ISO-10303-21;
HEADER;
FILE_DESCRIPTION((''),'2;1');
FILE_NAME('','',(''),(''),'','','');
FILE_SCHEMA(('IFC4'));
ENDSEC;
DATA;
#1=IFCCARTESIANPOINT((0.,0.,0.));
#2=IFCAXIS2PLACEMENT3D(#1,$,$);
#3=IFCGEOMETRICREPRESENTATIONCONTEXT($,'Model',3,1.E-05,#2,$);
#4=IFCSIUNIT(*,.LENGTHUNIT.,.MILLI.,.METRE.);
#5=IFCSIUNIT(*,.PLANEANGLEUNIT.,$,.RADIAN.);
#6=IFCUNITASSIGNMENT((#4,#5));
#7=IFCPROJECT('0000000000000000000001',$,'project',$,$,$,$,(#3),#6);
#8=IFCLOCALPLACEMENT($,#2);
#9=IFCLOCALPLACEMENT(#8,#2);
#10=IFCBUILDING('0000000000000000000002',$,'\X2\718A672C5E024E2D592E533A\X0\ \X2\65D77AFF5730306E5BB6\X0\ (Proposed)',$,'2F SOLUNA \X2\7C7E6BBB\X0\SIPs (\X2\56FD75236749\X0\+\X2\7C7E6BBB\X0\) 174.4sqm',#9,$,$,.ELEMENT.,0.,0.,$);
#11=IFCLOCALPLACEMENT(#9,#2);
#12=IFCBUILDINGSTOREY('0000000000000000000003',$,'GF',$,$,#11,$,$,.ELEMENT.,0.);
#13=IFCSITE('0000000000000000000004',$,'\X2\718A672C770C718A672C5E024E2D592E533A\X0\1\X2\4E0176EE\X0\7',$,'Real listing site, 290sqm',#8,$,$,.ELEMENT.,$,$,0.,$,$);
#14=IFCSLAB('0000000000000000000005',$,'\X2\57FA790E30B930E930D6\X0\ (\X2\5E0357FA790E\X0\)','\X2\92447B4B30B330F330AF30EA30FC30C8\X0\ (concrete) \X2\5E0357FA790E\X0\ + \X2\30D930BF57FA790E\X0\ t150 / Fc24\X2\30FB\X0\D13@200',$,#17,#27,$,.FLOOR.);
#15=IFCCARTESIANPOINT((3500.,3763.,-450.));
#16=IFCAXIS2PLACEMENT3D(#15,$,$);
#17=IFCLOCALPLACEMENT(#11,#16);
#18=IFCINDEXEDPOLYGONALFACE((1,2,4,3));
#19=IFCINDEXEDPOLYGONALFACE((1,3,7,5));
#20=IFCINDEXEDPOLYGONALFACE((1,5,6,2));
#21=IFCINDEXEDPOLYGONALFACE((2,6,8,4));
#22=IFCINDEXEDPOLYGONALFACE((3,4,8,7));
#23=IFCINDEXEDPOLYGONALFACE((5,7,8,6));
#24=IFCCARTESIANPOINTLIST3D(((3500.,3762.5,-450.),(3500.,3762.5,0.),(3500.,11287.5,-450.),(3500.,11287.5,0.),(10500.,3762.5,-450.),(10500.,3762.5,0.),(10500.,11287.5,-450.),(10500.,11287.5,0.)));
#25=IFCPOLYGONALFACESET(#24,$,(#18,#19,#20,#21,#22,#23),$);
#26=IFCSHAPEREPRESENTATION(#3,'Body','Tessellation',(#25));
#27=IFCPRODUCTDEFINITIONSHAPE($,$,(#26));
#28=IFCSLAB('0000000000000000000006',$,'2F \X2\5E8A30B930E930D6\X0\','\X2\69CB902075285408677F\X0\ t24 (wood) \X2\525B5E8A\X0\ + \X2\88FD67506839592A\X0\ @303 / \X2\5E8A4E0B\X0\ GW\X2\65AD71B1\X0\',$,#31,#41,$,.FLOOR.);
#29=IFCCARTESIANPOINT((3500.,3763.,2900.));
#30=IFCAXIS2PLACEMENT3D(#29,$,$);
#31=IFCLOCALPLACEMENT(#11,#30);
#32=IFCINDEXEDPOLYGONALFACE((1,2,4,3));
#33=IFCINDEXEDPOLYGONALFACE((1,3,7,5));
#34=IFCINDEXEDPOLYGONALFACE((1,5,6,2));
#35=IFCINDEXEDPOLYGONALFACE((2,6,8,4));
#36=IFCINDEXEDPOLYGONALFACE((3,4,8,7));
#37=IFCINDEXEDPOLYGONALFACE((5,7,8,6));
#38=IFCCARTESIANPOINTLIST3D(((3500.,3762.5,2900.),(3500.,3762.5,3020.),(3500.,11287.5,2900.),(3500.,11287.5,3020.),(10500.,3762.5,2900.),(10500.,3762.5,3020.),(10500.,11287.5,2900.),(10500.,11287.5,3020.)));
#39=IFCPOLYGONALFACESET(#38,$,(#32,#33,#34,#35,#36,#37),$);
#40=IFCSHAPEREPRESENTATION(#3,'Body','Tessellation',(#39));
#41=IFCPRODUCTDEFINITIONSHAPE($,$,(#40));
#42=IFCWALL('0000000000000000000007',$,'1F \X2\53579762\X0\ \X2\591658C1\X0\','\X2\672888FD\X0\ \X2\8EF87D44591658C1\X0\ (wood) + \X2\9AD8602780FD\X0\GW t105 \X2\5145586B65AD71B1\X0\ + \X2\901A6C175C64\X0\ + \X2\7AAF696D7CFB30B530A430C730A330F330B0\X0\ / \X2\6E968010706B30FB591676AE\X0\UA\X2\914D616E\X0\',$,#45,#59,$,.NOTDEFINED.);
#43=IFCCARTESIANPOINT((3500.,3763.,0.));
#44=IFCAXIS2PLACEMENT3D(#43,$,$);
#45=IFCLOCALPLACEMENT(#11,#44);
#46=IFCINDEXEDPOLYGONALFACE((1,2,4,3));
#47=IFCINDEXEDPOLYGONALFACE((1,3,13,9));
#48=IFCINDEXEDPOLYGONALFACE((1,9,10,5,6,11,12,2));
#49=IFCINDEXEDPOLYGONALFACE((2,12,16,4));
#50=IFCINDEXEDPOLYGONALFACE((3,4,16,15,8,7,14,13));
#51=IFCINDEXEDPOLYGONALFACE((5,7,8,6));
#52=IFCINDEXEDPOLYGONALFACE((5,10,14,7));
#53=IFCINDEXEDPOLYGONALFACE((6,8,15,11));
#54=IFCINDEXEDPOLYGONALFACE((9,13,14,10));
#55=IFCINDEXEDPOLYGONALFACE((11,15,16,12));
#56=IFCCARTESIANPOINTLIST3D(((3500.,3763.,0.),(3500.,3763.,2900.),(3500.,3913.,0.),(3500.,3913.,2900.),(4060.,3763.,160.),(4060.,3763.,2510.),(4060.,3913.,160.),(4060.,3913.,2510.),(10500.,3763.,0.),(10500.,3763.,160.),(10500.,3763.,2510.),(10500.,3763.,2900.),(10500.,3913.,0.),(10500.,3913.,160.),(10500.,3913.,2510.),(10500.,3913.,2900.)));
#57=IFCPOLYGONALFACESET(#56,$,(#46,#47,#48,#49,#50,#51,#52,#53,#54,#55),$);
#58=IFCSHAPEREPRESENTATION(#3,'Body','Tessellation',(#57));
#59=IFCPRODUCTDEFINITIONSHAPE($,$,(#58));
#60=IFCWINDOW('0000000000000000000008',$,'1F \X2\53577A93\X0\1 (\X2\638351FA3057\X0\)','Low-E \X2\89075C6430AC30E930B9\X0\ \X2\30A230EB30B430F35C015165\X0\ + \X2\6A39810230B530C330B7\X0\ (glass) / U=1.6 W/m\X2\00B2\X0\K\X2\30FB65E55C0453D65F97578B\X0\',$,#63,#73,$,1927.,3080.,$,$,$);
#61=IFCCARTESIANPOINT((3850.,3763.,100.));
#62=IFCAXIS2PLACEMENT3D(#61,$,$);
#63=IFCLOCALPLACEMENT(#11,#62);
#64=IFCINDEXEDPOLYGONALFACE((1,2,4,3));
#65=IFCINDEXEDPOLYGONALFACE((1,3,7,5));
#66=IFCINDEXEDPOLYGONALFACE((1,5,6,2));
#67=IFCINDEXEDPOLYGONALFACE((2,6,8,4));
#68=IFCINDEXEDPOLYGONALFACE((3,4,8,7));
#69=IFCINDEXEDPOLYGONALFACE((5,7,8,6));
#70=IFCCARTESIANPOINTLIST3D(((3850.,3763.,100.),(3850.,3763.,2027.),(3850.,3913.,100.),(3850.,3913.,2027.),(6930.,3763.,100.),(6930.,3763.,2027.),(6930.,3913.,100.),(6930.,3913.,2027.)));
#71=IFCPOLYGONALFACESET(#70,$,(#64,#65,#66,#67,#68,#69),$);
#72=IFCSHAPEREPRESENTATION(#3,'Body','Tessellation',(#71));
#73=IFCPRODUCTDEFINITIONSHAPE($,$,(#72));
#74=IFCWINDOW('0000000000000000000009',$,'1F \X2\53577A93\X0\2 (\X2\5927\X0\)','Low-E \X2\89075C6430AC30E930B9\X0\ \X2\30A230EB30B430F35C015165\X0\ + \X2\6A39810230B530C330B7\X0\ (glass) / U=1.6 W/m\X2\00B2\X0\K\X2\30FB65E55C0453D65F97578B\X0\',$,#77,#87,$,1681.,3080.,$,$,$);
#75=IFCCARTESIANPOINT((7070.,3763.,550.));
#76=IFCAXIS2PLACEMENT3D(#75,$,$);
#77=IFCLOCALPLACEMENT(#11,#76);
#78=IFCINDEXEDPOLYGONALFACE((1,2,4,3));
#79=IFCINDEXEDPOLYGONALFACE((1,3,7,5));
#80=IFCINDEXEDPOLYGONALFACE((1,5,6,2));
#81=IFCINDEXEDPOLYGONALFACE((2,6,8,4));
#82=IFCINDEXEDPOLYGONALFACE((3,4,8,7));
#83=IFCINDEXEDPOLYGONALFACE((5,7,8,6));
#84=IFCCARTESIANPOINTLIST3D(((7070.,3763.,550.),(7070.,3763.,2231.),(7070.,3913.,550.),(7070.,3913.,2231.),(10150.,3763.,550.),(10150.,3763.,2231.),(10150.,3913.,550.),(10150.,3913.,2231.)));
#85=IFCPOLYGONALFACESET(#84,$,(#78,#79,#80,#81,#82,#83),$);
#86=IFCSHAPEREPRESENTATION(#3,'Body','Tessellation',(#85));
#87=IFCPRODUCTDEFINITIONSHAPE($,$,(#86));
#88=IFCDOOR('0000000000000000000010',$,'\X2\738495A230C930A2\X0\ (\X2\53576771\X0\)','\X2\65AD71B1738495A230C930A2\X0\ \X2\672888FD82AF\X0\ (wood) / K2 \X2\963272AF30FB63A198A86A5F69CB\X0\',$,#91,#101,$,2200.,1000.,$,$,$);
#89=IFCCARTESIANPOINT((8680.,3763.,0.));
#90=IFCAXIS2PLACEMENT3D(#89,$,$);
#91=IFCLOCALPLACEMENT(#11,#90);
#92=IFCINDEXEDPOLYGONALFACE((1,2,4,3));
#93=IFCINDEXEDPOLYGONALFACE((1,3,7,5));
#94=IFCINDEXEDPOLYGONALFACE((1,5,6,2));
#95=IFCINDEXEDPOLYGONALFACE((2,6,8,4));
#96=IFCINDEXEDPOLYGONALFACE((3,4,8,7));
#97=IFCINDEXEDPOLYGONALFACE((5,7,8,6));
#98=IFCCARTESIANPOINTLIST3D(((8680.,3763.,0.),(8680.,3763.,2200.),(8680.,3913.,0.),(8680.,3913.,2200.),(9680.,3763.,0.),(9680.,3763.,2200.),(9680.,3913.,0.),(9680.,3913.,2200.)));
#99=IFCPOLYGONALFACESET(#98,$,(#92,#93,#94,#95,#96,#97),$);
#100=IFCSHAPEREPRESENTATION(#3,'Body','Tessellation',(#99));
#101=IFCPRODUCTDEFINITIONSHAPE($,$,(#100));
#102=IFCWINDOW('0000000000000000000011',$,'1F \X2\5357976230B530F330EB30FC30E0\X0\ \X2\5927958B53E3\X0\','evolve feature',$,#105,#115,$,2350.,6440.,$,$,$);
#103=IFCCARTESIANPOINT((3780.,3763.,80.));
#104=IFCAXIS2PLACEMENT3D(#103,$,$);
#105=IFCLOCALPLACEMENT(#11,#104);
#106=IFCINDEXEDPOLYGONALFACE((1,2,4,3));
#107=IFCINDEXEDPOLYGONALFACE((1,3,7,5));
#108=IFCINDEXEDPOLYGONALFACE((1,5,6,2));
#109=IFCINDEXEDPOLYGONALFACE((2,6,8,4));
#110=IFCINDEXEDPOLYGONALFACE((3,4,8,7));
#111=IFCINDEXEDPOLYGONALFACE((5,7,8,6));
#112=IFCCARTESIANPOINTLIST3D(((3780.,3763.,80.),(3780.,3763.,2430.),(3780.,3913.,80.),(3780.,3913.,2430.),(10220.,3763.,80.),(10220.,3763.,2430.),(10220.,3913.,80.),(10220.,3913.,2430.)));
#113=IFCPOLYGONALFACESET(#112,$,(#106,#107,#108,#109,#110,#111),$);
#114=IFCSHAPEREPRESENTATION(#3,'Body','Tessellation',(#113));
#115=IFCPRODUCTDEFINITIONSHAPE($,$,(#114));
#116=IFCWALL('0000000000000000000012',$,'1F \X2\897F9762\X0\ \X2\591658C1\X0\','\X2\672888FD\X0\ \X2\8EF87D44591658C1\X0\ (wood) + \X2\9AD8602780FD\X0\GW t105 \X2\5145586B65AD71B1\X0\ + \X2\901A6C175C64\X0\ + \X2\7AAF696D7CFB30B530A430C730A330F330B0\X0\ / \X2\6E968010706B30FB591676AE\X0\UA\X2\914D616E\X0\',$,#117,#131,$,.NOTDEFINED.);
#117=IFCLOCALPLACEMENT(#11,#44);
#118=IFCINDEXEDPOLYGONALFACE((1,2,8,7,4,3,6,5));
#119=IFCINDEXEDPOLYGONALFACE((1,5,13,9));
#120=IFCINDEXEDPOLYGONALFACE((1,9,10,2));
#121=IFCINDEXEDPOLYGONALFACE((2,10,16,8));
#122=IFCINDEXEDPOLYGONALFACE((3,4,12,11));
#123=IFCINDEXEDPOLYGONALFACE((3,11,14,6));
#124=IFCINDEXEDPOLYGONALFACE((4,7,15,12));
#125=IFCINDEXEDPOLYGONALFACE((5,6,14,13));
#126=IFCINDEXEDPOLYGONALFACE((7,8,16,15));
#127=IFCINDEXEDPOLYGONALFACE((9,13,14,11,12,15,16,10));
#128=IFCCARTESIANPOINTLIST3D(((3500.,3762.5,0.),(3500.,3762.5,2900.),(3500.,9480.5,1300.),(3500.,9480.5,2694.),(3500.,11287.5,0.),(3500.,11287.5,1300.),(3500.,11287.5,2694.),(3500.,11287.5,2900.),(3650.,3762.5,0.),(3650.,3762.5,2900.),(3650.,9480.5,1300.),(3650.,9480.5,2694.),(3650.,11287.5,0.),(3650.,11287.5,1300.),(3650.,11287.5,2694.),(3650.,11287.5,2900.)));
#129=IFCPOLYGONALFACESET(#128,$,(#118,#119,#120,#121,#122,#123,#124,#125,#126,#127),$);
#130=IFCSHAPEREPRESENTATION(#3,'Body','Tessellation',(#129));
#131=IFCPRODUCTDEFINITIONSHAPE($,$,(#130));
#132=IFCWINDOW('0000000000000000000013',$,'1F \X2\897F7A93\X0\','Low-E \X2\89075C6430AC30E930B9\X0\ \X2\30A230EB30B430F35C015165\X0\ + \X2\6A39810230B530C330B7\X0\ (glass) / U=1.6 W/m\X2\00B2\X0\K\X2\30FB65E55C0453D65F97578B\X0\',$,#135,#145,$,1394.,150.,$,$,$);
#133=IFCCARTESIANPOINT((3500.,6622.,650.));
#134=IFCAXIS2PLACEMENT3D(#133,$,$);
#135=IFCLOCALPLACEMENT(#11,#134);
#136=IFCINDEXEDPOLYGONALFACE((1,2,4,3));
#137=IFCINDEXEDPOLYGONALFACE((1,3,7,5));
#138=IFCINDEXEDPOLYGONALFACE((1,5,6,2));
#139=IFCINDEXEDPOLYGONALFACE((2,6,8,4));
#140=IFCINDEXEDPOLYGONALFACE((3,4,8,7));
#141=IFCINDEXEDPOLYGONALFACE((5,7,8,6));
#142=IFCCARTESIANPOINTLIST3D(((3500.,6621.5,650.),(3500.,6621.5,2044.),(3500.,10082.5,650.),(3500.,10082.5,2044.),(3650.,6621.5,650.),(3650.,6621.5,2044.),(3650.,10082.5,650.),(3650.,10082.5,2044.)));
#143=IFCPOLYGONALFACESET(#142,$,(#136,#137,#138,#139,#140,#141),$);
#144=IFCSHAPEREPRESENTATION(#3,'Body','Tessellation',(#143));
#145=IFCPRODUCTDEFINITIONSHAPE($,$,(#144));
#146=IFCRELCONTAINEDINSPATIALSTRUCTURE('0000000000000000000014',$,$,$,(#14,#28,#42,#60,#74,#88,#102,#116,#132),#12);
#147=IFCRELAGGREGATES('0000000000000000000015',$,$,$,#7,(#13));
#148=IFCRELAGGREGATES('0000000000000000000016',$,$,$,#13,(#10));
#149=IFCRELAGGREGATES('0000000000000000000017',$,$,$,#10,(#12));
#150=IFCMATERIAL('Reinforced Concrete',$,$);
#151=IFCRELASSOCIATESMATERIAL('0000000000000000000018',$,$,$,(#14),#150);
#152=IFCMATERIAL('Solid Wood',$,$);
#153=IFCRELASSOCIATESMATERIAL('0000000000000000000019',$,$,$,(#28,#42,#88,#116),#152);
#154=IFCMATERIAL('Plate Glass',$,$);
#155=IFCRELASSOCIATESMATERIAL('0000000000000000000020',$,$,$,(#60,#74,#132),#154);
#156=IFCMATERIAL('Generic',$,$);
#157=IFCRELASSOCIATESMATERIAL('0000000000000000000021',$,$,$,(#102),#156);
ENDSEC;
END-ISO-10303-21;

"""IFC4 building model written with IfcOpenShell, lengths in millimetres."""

from ifc_helpers import new_model, si_unit, frame, frame_2d, origin, place, context, project, spatial, rectangle, extrude, material, element, fill, save


model = new_model("IFC4")

# Units and contexts
model_context = context("Model", 3, precision=1e-05, world=origin())
ifc_project = project(units=[si_unit("LENGTHUNIT", "METRE", prefix="MILLI"), si_unit("PLANEANGLEUNIT", "RADIAN")], contexts=[model_context])

# Site, building, storey
site_placement = place(None, origin())
site = spatial("IfcSite", under=ifc_project, at=site_placement, Name="熊本県熊本市中央区1丁目7", ObjectType="Real listing site, 290sqm", CompositionType="ELEMENT", RefElevation=0.0)
building_placement = place(site_placement, origin())
building = spatial("IfcBuilding", under=site, at=building_placement, Name="熊本市中央区 旗竿地の家 (Proposed)", ObjectType="2F SOLUNA 籾殻SIPs (国産杉+籾殻) 174.4sqm", CompositionType="ELEMENT", ElevationOfRefHeight=0.0, ElevationOfTerrain=0.0)
storey_placement = place(building_placement, origin())
storey = spatial("IfcBuildingStorey", under=building, at=storey_placement, Name="GF", CompositionType="ELEMENT", Elevation=0.0)

# Slabs
ifc_material_1 = material(Name="Reinforced Concrete")
slab_1_placement = place(storey_placement, frame((3500.0, 3763.0, -450.0)))
element("IfcSlab", 1, at=slab_1_placement, inside=storey, material=ifc_material_1, Name="基礎スラブ (布基礎)", Description="鉄筋コンクリート (concrete) 布基礎 + ベタ基礎 t150 / Fc24・D13@200", PredefinedType="FLOOR", context=model_context, shape_type="SweptSolid", body=[
    extrude(rectangle(XDim=7000.0, YDim=7525.0, at=frame_2d((3500.0, 3762.0))), frame((3500.0, 3763.0, -450.0)), (0.0, 0.0, 1.0), 450.0),
])
ifc_material_2 = material(Name="Solid Wood")
slab_2_placement = place(storey_placement, frame((3500.0, 3763.0, 2900.0)))
element("IfcSlab", 2, at=slab_2_placement, inside=storey, material=ifc_material_2, Name="2F 床スラブ", Description="構造用合板 t24 (wood) 剛床 + 製材根太 @303 / 床下 GW断熱", PredefinedType="FLOOR", context=model_context, shape_type="SweptSolid", body=[
    extrude(rectangle(XDim=7000.0, YDim=7525.0, at=frame_2d((3500.0, 3762.0))), frame((3500.0, 3763.0, 2900.0)), (0.0, 0.0, 1.0), 120.0),
])
ifc_material_3 = material(Name="Generic")

# Wall, openings, windows, door
wall_1_placement = place(storey_placement, frame((3500.0, 3763.0, 0.0)))
wall_1 = element("IfcWall", 3, at=wall_1_placement, inside=storey, material=ifc_material_2, Name="1F 南面 外壁", Description="木製 軸組外壁 (wood) + 高性能GW t105 充填断熱 + 通気層 + 窯業系サイディング / 準耐火・外皮UA配慮", PredefinedType="NOTDEFINED", context=model_context, shape_type="SweptSolid", body=[
    extrude(rectangle(XDim=7000.0, YDim=150.0, at=frame_2d((3500.0, 75.0))), frame((3500.0, 3763.0, 0.0)), (0.0, 0.0, 1.0), 2900.0),
])
opening_1_placement = place(storey_placement, frame((3850.0, 3763.0, 100.0)))
opening_1 = element("IfcOpeningElement", 4, at=opening_1_placement, cuts=wall_1, PredefinedType="NOTDEFINED", context=model_context, shape_type="SweptSolid", body=[
    extrude(rectangle(XDim=3080.0, YDim=150.0, at=frame_2d((1540.0, 75.0))), frame((3850.0, 3763.0, 100.0)), (0.0, 0.0, 1.0), 1927.0),
])
opening_2_placement = place(storey_placement, frame((7070.0, 3763.0, 550.0)))
opening_2 = element("IfcOpeningElement", 5, at=opening_2_placement, cuts=wall_1, PredefinedType="NOTDEFINED", context=model_context, shape_type="SweptSolid", body=[
    extrude(rectangle(XDim=3080.0, YDim=150.0, at=frame_2d((1540.0, 75.0))), frame((7070.0, 3763.0, 550.0)), (0.0, 0.0, 1.0), 1681.0),
])
opening_3_placement = place(storey_placement, frame((8680.0, 3763.0, 0.0)))
opening_3 = element("IfcOpeningElement", 6, at=opening_3_placement, cuts=wall_1, PredefinedType="NOTDEFINED", context=model_context, shape_type="SweptSolid", body=[
    extrude(rectangle(XDim=1000.0, YDim=150.0, at=frame_2d((500.0, 75.0))), frame((8680.0, 3763.0, 0.0)), (0.0, 0.0, 1.0), 2200.0),
])
opening_4_placement = place(storey_placement, frame((3780.0, 3763.0, 80.0)))
opening_4 = element("IfcOpeningElement", 7, at=opening_4_placement, cuts=wall_1, PredefinedType="NOTDEFINED", context=model_context, shape_type="SweptSolid", body=[
    extrude(rectangle(XDim=6440.0, YDim=150.0, at=frame_2d((3220.0, 75.0))), frame((3780.0, 3763.0, 80.0)), (0.0, 0.0, 1.0), 2350.0),
])
ifc_material_4 = material(Name="Plate Glass")
window_1_placement = place(storey_placement, frame((3850.0, 3763.0, 100.0)))
window_1 = element("IfcWindow", 8, at=window_1_placement, inside=storey, material=ifc_material_4, Name="1F 南窓1 (掃出し)", Description="Low-E 複層ガラス アルゴン封入 + 樹脂サッシ (glass) / U=1.6 W/m²K・日射取得型", OverallHeight=1927.0, OverallWidth=3080.0, context=model_context, shape_type="SweptSolid", body=[
    extrude(rectangle(XDim=3080.0, YDim=150.0, at=frame_2d((1540.0, 75.0))), frame((3850.0, 3763.0, 100.0)), (0.0, 0.0, 1.0), 1927.0),
])
fill(opening_1, window_1)
window_2_placement = place(storey_placement, frame((7070.0, 3763.0, 550.0)))
window_2 = element("IfcWindow", 9, at=window_2_placement, inside=storey, material=ifc_material_4, Name="1F 南窓2 (大)", Description="Low-E 複層ガラス アルゴン封入 + 樹脂サッシ (glass) / U=1.6 W/m²K・日射取得型", OverallHeight=1681.0, OverallWidth=3080.0, context=model_context, shape_type="SweptSolid", body=[
    extrude(rectangle(XDim=3080.0, YDim=150.0, at=frame_2d((1540.0, 75.0))), frame((7070.0, 3763.0, 550.0)), (0.0, 0.0, 1.0), 1681.0),
])
fill(opening_2, window_2)
door_placement = place(storey_placement, frame((8680.0, 3763.0, 0.0)))
door = element("IfcDoor", 10, at=door_placement, inside=storey, material=ifc_material_2, Name="玄関ドア (南東)", Description="断熱玄関ドア 木製芯 (wood) / K2 防犯・採風機構", OverallHeight=2200.0, OverallWidth=1000.0, context=model_context, shape_type="SweptSolid", body=[
    extrude(rectangle(XDim=1000.0, YDim=150.0, at=frame_2d((500.0, 75.0))), frame((8680.0, 3763.0, 0.0)), (0.0, 0.0, 1.0), 2200.0),
])
fill(opening_3, door)
window_3_placement = place(storey_placement, frame((3780.0, 3763.0, 80.0)))
window_3 = element("IfcWindow", 11, at=window_3_placement, inside=storey, material=ifc_material_3, Name="1F 南面サンルーム 大開口", Description="evolve feature", OverallHeight=2350.0, OverallWidth=6440.0, context=model_context, shape_type="SweptSolid", body=[
    extrude(rectangle(XDim=6440.0, YDim=150.0, at=frame_2d((3220.0, 75.0))), frame((3780.0, 3763.0, 80.0)), (0.0, 0.0, 1.0), 2350.0),
])
fill(opening_4, window_3)

# Wall, opening, window
wall_2_placement = place(storey_placement, frame((3500.0, 3763.0, 0.0)))
wall_2 = element("IfcWall", 12, at=wall_2_placement, inside=storey, material=ifc_material_2, Name="1F 西面 外壁", Description="木製 軸組外壁 (wood) + 高性能GW t105 充填断熱 + 通気層 + 窯業系サイディング / 準耐火・外皮UA配慮", PredefinedType="NOTDEFINED", context=model_context, shape_type="SweptSolid", body=[
    extrude(rectangle(XDim=150.0, YDim=7525.0, at=frame_2d((75.0, 3762.0))), frame((3500.0, 3763.0, 0.0)), (0.0, 0.0, 1.0), 2900.0),
])
opening_5_placement = place(storey_placement, frame((3500.0, 6622.0, 650.0)))
opening_5 = element("IfcOpeningElement", 13, at=opening_5_placement, cuts=wall_2, PredefinedType="NOTDEFINED", context=model_context, shape_type="SweptSolid", body=[
    extrude(rectangle(XDim=150.0, YDim=3461.0, at=frame_2d((75.0, 1730.0))), frame((3500.0, 6622.0, 650.0)), (0.0, 0.0, 1.0), 1394.0),
])
window_4_placement = place(storey_placement, frame((3500.0, 6622.0, 650.0)))
window_4 = element("IfcWindow", 14, at=window_4_placement, inside=storey, material=ifc_material_4, Name="1F 西窓", Description="Low-E 複層ガラス アルゴン封入 + 樹脂サッシ (glass) / U=1.6 W/m²K・日射取得型", OverallHeight=1394.0, OverallWidth=150.0, context=model_context, shape_type="SweptSolid", body=[
    extrude(rectangle(XDim=150.0, YDim=3461.0, at=frame_2d((75.0, 1730.0))), frame((3500.0, 6622.0, 650.0)), (0.0, 0.0, 1.0), 1394.0),
])
fill(opening_5, window_4)

save(model, "model.ifc")
